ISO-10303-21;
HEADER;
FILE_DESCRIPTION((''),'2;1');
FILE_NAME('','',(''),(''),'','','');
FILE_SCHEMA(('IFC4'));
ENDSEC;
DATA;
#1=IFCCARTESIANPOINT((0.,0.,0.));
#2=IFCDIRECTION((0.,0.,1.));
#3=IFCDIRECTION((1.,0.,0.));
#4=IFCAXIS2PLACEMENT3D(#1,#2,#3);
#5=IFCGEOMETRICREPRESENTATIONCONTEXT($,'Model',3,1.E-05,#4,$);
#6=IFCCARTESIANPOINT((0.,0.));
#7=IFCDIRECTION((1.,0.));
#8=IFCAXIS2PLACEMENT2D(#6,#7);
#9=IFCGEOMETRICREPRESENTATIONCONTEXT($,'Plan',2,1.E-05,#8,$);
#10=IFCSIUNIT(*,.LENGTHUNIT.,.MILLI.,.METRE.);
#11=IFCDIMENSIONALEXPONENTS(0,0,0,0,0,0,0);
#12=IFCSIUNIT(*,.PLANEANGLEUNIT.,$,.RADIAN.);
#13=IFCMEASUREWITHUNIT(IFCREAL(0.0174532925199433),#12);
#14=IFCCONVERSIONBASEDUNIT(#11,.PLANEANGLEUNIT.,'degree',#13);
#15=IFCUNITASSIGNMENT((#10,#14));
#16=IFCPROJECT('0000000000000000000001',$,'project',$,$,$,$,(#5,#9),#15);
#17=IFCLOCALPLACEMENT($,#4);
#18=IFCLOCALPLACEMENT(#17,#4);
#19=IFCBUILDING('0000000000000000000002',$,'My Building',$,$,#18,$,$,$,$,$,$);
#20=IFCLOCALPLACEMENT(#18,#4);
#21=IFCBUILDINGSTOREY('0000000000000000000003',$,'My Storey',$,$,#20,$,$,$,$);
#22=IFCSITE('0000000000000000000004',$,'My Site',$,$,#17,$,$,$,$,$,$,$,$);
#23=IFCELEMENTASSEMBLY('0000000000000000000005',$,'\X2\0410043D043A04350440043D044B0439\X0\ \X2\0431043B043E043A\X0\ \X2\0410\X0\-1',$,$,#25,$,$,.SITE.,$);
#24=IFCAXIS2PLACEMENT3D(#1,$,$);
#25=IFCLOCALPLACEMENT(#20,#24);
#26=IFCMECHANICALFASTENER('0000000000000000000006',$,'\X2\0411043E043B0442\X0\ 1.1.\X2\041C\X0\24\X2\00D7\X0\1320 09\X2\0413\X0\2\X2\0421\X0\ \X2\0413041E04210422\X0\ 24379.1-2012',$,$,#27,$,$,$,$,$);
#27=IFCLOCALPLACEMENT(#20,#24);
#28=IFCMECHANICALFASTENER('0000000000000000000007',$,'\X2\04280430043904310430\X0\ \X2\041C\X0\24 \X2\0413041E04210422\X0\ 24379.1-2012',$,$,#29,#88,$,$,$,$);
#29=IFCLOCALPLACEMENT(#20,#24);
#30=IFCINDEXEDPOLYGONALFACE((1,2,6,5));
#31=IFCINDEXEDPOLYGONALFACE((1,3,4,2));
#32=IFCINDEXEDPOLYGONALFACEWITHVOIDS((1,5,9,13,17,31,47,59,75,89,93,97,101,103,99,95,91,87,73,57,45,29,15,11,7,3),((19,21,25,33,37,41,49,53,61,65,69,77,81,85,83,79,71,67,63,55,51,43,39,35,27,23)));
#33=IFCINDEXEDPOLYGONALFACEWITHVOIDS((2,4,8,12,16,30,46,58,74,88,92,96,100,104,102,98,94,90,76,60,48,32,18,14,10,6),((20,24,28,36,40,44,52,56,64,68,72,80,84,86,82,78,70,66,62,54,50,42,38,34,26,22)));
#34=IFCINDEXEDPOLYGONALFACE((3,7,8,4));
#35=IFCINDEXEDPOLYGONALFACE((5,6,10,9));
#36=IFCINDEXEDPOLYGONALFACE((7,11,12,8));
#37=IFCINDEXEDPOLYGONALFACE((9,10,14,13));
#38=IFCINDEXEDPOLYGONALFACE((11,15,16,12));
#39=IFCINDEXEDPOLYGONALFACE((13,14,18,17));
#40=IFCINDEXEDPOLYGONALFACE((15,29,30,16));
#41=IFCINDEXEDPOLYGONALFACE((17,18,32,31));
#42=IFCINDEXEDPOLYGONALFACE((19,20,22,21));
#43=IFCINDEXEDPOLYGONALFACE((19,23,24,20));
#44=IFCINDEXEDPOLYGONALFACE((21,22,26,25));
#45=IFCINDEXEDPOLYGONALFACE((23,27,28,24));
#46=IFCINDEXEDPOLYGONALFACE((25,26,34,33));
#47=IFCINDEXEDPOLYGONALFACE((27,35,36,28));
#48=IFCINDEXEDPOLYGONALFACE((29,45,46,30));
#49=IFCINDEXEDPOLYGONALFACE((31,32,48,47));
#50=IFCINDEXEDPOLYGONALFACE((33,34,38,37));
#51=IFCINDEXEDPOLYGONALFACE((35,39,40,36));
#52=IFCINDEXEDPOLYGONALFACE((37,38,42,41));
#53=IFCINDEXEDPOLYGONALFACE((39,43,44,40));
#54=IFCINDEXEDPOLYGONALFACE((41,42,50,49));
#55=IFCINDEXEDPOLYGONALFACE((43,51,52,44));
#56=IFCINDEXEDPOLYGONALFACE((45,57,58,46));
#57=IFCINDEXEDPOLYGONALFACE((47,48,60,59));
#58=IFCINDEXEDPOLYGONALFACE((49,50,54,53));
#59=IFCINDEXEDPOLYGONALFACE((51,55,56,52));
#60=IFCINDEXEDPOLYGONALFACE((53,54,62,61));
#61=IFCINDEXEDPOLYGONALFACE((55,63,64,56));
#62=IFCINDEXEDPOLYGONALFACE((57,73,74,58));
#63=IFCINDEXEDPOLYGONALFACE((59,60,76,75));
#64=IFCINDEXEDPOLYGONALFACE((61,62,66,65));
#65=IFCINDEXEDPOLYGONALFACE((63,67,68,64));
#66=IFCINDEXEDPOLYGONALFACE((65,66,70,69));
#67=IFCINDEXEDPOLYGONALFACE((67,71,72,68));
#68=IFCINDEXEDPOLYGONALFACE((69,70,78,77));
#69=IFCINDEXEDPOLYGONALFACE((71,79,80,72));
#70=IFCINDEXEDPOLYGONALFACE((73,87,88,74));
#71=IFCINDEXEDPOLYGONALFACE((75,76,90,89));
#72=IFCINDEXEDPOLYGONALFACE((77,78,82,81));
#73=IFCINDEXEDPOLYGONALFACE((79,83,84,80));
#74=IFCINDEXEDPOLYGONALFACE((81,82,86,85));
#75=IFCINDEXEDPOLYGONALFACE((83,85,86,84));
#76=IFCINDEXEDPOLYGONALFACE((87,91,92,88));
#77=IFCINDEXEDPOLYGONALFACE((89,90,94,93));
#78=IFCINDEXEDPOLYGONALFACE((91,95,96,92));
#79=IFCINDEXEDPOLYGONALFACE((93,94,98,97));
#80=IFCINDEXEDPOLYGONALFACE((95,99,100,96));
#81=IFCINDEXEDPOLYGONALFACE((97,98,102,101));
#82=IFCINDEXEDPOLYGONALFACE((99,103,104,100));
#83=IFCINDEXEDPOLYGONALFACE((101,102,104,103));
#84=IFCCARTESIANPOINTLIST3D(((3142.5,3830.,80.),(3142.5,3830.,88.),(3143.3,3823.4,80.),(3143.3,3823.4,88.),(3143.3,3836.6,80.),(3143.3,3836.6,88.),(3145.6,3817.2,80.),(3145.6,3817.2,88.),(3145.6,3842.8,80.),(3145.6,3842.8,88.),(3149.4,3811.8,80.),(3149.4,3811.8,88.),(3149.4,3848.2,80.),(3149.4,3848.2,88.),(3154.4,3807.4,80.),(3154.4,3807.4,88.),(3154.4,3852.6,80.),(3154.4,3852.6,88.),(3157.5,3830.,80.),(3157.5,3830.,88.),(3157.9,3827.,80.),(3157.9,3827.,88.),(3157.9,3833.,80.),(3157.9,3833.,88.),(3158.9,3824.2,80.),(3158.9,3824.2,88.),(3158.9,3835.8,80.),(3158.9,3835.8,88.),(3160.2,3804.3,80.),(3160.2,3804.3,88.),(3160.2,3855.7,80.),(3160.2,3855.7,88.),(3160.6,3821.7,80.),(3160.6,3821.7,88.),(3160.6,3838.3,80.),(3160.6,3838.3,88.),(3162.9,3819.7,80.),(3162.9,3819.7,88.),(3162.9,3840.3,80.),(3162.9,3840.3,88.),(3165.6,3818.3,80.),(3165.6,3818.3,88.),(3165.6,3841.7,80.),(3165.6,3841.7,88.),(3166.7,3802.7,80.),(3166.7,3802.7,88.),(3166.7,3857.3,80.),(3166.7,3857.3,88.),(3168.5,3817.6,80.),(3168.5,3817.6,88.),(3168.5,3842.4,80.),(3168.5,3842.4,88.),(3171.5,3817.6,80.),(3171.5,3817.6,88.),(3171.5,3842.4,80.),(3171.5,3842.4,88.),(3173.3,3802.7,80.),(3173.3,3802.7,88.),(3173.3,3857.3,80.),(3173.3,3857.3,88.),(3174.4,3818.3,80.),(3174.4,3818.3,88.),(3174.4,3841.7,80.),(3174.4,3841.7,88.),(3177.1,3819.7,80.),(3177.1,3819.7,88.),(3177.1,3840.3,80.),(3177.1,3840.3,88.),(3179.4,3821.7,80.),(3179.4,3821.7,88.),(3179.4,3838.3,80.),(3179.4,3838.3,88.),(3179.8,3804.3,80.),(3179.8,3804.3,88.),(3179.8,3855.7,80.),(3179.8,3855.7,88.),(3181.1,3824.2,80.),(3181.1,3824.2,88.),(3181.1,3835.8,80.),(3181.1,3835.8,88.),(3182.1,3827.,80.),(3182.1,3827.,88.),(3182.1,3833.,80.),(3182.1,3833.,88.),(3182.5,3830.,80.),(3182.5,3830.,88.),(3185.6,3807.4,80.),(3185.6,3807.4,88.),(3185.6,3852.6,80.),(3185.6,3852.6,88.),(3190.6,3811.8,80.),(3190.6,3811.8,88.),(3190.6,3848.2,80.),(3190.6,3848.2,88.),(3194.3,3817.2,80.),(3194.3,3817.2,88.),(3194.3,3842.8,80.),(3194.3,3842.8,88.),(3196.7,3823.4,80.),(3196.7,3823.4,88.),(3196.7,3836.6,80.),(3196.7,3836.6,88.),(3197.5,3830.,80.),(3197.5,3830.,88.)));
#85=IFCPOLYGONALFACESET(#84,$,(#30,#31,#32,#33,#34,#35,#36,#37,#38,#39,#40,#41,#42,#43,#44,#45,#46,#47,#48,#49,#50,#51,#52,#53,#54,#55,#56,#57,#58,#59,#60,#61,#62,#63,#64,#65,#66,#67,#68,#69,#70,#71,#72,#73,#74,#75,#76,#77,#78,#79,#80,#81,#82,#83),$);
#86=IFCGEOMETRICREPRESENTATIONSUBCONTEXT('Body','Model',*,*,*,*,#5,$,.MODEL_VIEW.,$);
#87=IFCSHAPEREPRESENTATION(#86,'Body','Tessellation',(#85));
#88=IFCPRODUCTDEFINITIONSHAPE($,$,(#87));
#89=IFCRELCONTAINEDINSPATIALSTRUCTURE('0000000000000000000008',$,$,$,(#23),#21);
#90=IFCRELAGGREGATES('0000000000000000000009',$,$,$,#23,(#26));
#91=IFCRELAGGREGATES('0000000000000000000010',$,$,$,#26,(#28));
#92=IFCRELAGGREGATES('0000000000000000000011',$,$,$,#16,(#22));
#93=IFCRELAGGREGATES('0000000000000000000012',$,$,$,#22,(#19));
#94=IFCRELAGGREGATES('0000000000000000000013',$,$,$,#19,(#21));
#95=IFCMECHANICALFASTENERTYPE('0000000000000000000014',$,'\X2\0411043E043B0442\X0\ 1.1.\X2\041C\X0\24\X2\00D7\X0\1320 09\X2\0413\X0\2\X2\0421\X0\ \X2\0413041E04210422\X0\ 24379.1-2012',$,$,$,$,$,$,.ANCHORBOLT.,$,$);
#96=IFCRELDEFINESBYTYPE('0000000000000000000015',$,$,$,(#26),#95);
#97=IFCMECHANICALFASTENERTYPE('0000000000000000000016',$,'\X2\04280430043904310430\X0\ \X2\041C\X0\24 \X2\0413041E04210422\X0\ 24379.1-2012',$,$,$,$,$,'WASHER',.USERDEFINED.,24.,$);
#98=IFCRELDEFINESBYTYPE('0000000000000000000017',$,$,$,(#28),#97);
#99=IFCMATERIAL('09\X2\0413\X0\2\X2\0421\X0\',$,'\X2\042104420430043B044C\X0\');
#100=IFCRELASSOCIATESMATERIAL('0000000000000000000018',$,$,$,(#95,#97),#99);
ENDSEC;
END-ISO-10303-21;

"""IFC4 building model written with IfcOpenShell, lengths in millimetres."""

from ifc_helpers import new_model, entity, si_unit, converted_unit, frame, origin_with_axes, origin_2d_with_axis, place, context, subcontext, project, spatial, polyline, outline, extrude, source, transform, mapped, material, type_object, type_shapes, element, aggregate, save


model = new_model("IFC4")

# Units and contexts
model_context = context("Model", 3, precision=1e-05, world=origin_with_axes())
plan_context = context("Plan", 2, precision=1e-05, world=origin_2d_with_axis())
body_context = subcontext(model_context, "Body", "Model", "MODEL_VIEW")
ifc_project = project(units=[si_unit("LENGTHUNIT", "METRE", prefix="MILLI"), converted_unit("PLANEANGLEUNIT", "degree", entity("IfcReal", 0.0174532925199433), si_unit("PLANEANGLEUNIT", "RADIAN"), dimensions=[0, 0, 0, 0, 0, 0, 0])], contexts=[model_context, plan_context])

# Site, building, storey
site_placement = place(None, origin_with_axes())
site = spatial("IfcSite", under=ifc_project, at=site_placement, Name="My Site")
building_placement = place(site_placement, origin_with_axes())
building = spatial("IfcBuilding", under=site, at=building_placement, Name="My Building")
storey_placement = place(building_placement, origin_with_axes())
storey = spatial("IfcBuildingStorey", under=building, at=storey_placement, Name="My Storey")

# Element assembly, mechanical fastener
ifc_material_1 = material(Name="09Г2С", Category="Сталь")
mechanical_fastener_type_1 = type_object("IfcMechanicalFastenerType", Name="Болт 1.1.М24×1320 09Г2С ГОСТ 24379.1-2012", PredefinedType="ANCHORBOLT", material=ifc_material_1)
assembly_1_placement = place(storey_placement, frame((3000.0, 4000.0, 0.0), z_axis=(0.0, 0.0, 1.0), x_axis=(1.0, 0.0, 0.0)))
assembly_1 = element("IfcElementAssembly", 1, at=assembly_1_placement, inside=storey, Name="Анкерный блок А-1", AssemblyPlace="SITE")
mechanical_fastener_1_placement = place(assembly_1_placement, frame((170.0, -170.0, 0.0), z_axis=(0.0, 0.0, 1.0), x_axis=(1.0, 0.0, 0.0)))
mechanical_fastener_1 = element("IfcMechanicalFastener", 2, at=mechanical_fastener_1_placement, type_object=mechanical_fastener_type_1, Name="Болт 1.1.М24×1320 09Г2С ГОСТ 24379.1-2012")
aggregate(assembly_1, [mechanical_fastener_1])

# Mechanical fastener
mechanical_fastener_type_2 = type_object("IfcMechanicalFastenerType", Name="Шайба М24 ГОСТ 24379.1-2012", ElementType="WASHER", NominalDiameter=24.0, PredefinedType="USERDEFINED", material=ifc_material_1)
shared_shape_1 = source(origin_with_axes(), body_context, "Body", "SweptSolid", [
    extrude(outline(polyline([(27.5, 0.0), (26.7, 6.6), (24.4, 12.8), (20.6, 18.2), (15.6, 22.6), (9.8, 25.7), (3.3, 27.3), (-3.3, 27.3), (-9.8, 25.7), (-15.6, 22.6), (-20.6, 18.2), (-24.4, 12.8), (-26.7, 6.6), (-27.5, 0.0), (-26.7, -6.6), (-24.4, -12.8), (-20.6, -18.2), (-15.6, -22.6), (-9.8, -25.7), (-3.3, -27.3), (3.3, -27.3), (9.8, -25.7), (15.6, -22.6), (20.6, -18.2), (24.4, -12.8), (26.7, -6.6), (27.5, 0.0)]), holes=[polyline([(-4.4, -11.7), (-7.1, -10.3), (-9.4, -8.3), (-11.1, -5.8), (-12.1, -3.0), (-12.5, 0.0), (-12.1, 3.0), (-11.1, 5.8), (-9.4, 8.3), (-7.1, 10.3), (-4.4, 11.7), (-1.5, 12.4), (1.5, 12.4), (4.4, 11.7), (7.1, 10.3), (9.4, 8.3), (11.1, 5.8), (12.1, 3.0), (12.5, 0.0), (12.1, -3.0), (11.1, -5.8), (9.4, -8.3), (7.1, -10.3), (4.4, -11.7), (1.5, -12.4), (-1.5, -12.4), (-4.4, -11.7)])]), frame((0.0, 0.0, 0.0), z_axis=(0.0, 0.0, 1.0), x_axis=(0.120537, -0.992709, 0.0)), (0.0, 0.0, 1.0), 8.0),
])
type_shapes(mechanical_fastener_type_2, [shared_shape_1])
mechanical_fastener_2_placement = place(mechanical_fastener_1_placement, frame((0.0, 0.0, 80.0), z_axis=(0.0, 0.0, 1.0), x_axis=(1.0, 0.0, 0.0)))
mechanical_fastener_2 = element("IfcMechanicalFastener", 3, at=mechanical_fastener_2_placement, type_object=mechanical_fastener_type_2, Name="Шайба М24 ГОСТ 24379.1-2012", context=body_context, shape_type="MappedRepresentation", body=[
    mapped(shared_shape_1, transform((0.0, 0.0, 0.0), x_axis=(1.0, 0.0, 0.0), y_axis=(0.0, 1.0, 0.0), z_axis=(0.0, 0.0, 1.0), scale=1.0)),
])
aggregate(mechanical_fastener_1, [mechanical_fastener_2])

save(model, "model.ifc")
